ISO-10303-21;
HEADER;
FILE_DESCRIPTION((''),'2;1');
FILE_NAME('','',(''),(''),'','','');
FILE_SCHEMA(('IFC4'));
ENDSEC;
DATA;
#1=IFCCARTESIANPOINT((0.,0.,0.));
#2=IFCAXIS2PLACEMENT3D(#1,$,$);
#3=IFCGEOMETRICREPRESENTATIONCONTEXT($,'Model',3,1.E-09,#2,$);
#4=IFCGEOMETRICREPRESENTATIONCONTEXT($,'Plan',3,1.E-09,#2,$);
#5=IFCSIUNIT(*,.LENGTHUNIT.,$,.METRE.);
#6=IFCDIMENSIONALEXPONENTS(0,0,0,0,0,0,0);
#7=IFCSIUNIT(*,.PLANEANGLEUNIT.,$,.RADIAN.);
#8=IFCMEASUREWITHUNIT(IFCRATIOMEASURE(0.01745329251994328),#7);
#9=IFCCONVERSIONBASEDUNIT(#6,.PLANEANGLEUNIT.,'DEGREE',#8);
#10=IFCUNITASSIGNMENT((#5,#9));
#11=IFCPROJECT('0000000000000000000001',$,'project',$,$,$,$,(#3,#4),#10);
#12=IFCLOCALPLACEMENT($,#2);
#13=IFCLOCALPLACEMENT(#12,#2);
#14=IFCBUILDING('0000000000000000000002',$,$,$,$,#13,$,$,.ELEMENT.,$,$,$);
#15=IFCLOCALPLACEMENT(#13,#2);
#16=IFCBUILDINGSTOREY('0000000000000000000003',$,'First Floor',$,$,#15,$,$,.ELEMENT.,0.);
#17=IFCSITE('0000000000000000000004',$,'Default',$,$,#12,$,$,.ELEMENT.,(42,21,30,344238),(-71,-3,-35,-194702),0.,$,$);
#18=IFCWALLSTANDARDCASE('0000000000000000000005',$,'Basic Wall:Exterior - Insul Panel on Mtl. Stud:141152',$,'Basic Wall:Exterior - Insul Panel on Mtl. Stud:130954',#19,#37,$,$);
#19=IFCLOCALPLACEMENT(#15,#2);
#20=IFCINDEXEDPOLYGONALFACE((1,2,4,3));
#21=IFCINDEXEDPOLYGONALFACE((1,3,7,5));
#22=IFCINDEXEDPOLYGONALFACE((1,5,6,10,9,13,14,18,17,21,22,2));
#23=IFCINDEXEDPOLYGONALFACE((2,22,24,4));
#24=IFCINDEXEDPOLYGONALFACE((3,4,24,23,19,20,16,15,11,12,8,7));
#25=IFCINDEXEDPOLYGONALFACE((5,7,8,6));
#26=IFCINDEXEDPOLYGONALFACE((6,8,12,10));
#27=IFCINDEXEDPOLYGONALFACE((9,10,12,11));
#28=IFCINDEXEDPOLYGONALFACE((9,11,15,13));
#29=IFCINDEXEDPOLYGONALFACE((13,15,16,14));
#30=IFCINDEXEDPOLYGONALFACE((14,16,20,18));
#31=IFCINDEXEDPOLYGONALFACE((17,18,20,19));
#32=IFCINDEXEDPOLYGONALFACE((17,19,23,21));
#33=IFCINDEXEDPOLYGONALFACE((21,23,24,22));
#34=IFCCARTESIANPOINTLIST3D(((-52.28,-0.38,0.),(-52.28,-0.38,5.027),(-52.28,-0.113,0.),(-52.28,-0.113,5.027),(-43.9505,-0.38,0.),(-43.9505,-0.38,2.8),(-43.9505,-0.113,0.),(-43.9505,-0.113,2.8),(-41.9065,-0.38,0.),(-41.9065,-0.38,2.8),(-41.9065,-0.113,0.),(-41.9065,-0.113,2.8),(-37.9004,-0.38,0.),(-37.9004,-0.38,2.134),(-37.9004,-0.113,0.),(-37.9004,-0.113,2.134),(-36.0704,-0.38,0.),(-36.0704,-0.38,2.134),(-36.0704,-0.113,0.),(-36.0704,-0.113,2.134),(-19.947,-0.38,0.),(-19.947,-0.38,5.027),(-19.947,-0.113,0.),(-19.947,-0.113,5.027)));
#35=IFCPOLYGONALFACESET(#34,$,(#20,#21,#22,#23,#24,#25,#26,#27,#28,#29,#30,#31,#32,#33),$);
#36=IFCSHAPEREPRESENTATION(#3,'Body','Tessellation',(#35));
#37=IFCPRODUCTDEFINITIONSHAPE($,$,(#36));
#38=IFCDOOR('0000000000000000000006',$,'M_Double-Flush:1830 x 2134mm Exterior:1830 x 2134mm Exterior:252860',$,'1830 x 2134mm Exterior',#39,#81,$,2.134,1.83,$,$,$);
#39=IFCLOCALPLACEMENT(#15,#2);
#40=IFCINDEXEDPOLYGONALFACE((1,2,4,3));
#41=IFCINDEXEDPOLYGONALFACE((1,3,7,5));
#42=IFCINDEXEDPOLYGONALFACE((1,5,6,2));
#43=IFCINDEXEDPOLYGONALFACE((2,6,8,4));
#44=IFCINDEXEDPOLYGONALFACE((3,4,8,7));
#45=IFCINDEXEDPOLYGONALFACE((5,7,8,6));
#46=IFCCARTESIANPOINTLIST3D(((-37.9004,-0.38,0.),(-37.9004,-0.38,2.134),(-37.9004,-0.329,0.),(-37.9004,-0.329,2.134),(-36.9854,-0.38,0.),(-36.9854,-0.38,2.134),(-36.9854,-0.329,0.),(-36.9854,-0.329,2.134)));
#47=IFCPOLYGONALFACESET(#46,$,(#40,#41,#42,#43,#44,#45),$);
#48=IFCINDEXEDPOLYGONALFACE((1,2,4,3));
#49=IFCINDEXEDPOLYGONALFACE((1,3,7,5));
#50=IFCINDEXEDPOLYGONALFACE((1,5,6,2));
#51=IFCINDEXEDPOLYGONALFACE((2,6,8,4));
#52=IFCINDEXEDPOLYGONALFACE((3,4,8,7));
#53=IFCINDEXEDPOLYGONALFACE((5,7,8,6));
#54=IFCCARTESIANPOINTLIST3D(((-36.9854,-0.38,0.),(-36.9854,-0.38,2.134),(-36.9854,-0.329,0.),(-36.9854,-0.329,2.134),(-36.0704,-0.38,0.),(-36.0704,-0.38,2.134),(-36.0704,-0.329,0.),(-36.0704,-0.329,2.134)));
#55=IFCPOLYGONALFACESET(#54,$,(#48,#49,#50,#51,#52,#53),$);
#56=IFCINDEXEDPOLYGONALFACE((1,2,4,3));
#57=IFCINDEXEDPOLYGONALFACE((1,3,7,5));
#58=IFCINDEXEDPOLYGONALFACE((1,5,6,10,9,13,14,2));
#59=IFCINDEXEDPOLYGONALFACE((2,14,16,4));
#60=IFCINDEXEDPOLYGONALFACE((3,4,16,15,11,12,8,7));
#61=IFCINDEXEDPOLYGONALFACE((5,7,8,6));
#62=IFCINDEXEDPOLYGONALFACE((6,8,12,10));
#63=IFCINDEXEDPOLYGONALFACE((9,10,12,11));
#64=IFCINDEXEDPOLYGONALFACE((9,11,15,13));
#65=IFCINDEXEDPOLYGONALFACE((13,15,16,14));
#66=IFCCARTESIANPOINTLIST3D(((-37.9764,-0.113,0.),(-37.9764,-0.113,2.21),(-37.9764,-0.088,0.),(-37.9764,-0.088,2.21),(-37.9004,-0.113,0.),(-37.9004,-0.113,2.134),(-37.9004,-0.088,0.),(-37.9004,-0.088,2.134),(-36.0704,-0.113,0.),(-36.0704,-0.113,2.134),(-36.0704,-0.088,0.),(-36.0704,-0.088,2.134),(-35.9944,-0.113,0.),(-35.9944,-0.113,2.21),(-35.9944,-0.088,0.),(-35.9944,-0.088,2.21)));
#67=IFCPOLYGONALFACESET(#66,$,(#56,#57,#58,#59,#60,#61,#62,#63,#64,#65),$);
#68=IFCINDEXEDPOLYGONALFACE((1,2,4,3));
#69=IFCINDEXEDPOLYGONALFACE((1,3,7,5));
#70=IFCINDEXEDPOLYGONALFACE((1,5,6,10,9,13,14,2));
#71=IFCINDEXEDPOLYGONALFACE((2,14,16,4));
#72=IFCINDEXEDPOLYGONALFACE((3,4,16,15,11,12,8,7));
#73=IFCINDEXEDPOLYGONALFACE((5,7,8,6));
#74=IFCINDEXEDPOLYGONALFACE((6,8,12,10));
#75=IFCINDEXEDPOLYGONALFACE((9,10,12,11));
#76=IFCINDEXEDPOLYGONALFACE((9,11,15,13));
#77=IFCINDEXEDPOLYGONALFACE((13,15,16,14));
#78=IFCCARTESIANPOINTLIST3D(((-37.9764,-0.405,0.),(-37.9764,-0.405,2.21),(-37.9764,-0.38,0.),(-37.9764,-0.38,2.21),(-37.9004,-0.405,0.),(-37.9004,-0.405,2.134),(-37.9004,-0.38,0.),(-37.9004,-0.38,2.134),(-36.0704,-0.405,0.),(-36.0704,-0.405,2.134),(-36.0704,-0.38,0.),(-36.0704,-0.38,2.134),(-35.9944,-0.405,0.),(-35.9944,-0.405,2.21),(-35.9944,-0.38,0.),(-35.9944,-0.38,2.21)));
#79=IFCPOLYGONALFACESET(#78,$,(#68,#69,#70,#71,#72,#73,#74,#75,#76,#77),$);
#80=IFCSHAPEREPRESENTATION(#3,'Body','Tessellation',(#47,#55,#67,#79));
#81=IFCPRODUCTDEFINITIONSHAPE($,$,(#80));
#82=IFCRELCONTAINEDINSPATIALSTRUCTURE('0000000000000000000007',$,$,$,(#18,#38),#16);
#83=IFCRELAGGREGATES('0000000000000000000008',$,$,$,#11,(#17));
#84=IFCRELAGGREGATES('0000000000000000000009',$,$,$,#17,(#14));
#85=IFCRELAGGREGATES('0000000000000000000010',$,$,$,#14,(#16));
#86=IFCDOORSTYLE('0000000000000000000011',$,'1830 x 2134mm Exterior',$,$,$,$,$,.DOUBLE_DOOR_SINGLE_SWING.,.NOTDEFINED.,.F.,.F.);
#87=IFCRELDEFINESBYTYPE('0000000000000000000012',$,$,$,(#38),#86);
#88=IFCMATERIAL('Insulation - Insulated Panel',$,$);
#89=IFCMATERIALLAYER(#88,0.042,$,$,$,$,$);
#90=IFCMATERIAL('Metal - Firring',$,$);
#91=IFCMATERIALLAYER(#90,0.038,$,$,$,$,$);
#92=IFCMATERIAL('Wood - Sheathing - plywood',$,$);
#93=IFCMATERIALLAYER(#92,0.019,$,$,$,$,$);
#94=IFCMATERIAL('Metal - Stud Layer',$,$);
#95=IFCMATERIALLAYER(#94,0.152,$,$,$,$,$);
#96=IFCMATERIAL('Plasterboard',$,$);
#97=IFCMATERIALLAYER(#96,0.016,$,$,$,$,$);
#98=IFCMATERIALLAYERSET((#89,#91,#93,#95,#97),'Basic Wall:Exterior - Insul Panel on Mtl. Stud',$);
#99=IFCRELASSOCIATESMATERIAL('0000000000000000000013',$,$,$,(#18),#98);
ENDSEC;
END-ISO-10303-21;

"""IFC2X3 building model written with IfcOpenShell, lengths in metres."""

from ifc_helpers import new_model, entity, si_unit, converted_unit, frame, frame_2d, origin, origin_2d_with_axis, place, context, project, spatial, polyline, rectangle, outline, extrude, source, transform, mapped, material, layer, layer_set, layer_usage, type_object, type_shapes, element, fill, save


model = new_model("IFC2X3")

# Units and contexts
model_context = context("Model", 3, precision=1e-09, world=origin())
plan_context = context("Plan", 3, precision=1e-09, world=origin())
ifc_project = project(units=[si_unit("LENGTHUNIT", "METRE"), converted_unit("PLANEANGLEUNIT", "DEGREE", entity("IfcRatioMeasure", 0.01745329251994328), si_unit("PLANEANGLEUNIT", "RADIAN"), dimensions=[0, 0, 0, 0, 0, 0, 0])], contexts=[model_context, plan_context])

# Site, building, storey
site_placement = place(None, origin())
site = spatial("IfcSite", under=ifc_project, at=site_placement, Name="Default", CompositionType="ELEMENT", RefLatitude=(42, 21, 30, 344238), RefLongitude=(-71, -3, -35, -194702), RefElevation=0.0)
building_placement = place(site_placement, origin())
building = spatial("IfcBuilding", under=site, at=building_placement, CompositionType="ELEMENT")
storey_placement = place(building_placement, origin())
storey = spatial("IfcBuildingStorey", under=building, at=storey_placement, Name="First Floor", CompositionType="ELEMENT", Elevation=0.0)

# Wall, openings, door
ifc_material_1 = material(Name="Insulation - Insulated Panel")
ifc_layer_1 = layer(ifc_material_1, 0.042)
ifc_material_2 = material(Name="Metal - Firring")
ifc_layer_2 = layer(ifc_material_2, 0.038)
ifc_material_3 = material(Name="Wood - Sheathing - plywood")
ifc_layer_3 = layer(ifc_material_3, 0.019)
ifc_material_4 = material(Name="Metal - Stud Layer")
ifc_layer_4 = layer(ifc_material_4, 0.152)
ifc_material_5 = material(Name="Plasterboard")
ifc_layer_5 = layer(ifc_material_5, 0.016)
ifc_layer_set_1 = layer_set([ifc_layer_1, ifc_layer_2, ifc_layer_3, ifc_layer_4, ifc_layer_5], Name="Basic Wall:Exterior - Insul Panel on Mtl. Stud")
ifc_layer_usage_1 = layer_usage(ifc_layer_set_1, "AXIS2", "NEGATIVE", 0.1335)
wall_1_placement = place(storey_placement, frame((-19.947, -0.2465, 0.0), z_axis=(0.0, 0.0, 1.0), x_axis=(-1.0, 0.0, 0.0)))
wall_1 = element("IfcWallStandardCase", 1, at=wall_1_placement, inside=storey, material=ifc_layer_usage_1, Name="Basic Wall:Exterior - Insul Panel on Mtl. Stud:141152", ObjectType="Basic Wall:Exterior - Insul Panel on Mtl. Stud:130954", context=model_context, shape_type="SweptSolid", body=[
    extrude(rectangle(XDim=32.333, YDim=0.267, at=frame_2d((16.1665, 0.0), x_axis=(-1.0, 0.0))), origin(), (0.0, 0.0, 1.0), 5.027),
])
opening_1_placement = place(wall_1_placement, frame((22.9815, 0.1335, 1.4)))
element("IfcOpeningElement", 2, at=opening_1_placement, cuts=wall_1, ObjectType="Opening", context=model_context, shape_type="SweptSolid", body=[
    extrude(rectangle(XDim=2.8, YDim=2.044, at=frame_2d((0.0, 0.0), x_axis=(0.0, 1.0))), frame((0.0, 0.0, 0.0), z_axis=(0.0, -1.0, 0.0), x_axis=(1.0, 0.0, 0.0)), (0.0, 0.0, 1.0), 0.267),
])
opening_2_placement = place(wall_1_placement, frame((16.1234, -0.1335, 0.0)))
opening_2 = element("IfcOpeningElement", 3, at=opening_2_placement, cuts=wall_1, ObjectType="Opening", context=model_context, shape_type="SweptSolid", body=[
    extrude(rectangle(XDim=2.134, YDim=1.83, at=frame_2d((1.067, 0.915), x_axis=(1.0, 0.0))), frame((0.0, 0.0, 0.0), z_axis=(0.0, 1.0, 0.0), x_axis=(0.0, 0.0, 1.0)), (0.0, 0.0, 1.0), 0.267),
])
door_style_1 = type_object("IfcDoorStyle", Name="1830 x 2134mm Exterior", ConstructionType="NOTDEFINED", OperationType="DOUBLE_DOOR_SINGLE_SWING", ParameterTakesPrecedence=False, Sizeable=False)
shared_shape_1 = source(origin(), model_context, "Body", "SweptSolid", [
    extrude(rectangle(XDim=0.051, YDim=0.915, at=origin_2d_with_axis()), frame((1.3725, 0.2415, 0.0), z_axis=(0.0, 0.0, 1.0), x_axis=(0.0, -1.0, 0.0)), (0.0, 0.0, 1.0), 2.134),
    extrude(rectangle(XDim=0.051, YDim=0.915, at=origin_2d_with_axis()), frame((0.4575, 0.2415, 0.0), z_axis=(0.0, 0.0, 1.0), x_axis=(0.0, -1.0, 0.0)), (0.0, 0.0, 1.0), 2.134),
    extrude(outline(polyline([(-1.048, 0.915), (1.086, 0.915), (1.086, 0.991), (-1.124, 0.991), (-1.124, -0.991), (1.086, -0.991), (1.086, -0.915), (-1.048, -0.915), (-1.048, 0.915)])), frame((0.915, -0.025, 1.086), z_axis=(0.0, 1.0, 0.0), x_axis=(0.0, 0.0, -1.0)), (0.0, 0.0, 1.0), 0.025),
    extrude(outline(polyline([(-1.048, 0.915), (1.086, 0.915), (1.086, 0.991), (-1.124, 0.991), (-1.124, -0.991), (1.086, -0.991), (1.086, -0.915), (-1.048, -0.915), (-1.048, 0.915)])), frame((0.915, 0.267, 1.086), z_axis=(0.0, 1.0, 0.0), x_axis=(0.0, 0.0, -1.0)), (0.0, 0.0, 1.0), 0.025),
])
type_shapes(door_style_1, [shared_shape_1])
door_1_placement = place(opening_2_placement, origin())
door_1 = element("IfcDoor", 4, at=door_1_placement, inside=storey, type_object=door_style_1, Name="M_Double-Flush:1830 x 2134mm Exterior:1830 x 2134mm Exterior:252860", ObjectType="1830 x 2134mm Exterior", OverallHeight=2.134, OverallWidth=1.83, context=model_context, shape_type="MappedRepresentation", body=[
    mapped(shared_shape_1, transform((0.0, 0.0, 0.0), scale=1.0)),
])
fill(opening_2, door_1)

save(model, "model.ifc")
